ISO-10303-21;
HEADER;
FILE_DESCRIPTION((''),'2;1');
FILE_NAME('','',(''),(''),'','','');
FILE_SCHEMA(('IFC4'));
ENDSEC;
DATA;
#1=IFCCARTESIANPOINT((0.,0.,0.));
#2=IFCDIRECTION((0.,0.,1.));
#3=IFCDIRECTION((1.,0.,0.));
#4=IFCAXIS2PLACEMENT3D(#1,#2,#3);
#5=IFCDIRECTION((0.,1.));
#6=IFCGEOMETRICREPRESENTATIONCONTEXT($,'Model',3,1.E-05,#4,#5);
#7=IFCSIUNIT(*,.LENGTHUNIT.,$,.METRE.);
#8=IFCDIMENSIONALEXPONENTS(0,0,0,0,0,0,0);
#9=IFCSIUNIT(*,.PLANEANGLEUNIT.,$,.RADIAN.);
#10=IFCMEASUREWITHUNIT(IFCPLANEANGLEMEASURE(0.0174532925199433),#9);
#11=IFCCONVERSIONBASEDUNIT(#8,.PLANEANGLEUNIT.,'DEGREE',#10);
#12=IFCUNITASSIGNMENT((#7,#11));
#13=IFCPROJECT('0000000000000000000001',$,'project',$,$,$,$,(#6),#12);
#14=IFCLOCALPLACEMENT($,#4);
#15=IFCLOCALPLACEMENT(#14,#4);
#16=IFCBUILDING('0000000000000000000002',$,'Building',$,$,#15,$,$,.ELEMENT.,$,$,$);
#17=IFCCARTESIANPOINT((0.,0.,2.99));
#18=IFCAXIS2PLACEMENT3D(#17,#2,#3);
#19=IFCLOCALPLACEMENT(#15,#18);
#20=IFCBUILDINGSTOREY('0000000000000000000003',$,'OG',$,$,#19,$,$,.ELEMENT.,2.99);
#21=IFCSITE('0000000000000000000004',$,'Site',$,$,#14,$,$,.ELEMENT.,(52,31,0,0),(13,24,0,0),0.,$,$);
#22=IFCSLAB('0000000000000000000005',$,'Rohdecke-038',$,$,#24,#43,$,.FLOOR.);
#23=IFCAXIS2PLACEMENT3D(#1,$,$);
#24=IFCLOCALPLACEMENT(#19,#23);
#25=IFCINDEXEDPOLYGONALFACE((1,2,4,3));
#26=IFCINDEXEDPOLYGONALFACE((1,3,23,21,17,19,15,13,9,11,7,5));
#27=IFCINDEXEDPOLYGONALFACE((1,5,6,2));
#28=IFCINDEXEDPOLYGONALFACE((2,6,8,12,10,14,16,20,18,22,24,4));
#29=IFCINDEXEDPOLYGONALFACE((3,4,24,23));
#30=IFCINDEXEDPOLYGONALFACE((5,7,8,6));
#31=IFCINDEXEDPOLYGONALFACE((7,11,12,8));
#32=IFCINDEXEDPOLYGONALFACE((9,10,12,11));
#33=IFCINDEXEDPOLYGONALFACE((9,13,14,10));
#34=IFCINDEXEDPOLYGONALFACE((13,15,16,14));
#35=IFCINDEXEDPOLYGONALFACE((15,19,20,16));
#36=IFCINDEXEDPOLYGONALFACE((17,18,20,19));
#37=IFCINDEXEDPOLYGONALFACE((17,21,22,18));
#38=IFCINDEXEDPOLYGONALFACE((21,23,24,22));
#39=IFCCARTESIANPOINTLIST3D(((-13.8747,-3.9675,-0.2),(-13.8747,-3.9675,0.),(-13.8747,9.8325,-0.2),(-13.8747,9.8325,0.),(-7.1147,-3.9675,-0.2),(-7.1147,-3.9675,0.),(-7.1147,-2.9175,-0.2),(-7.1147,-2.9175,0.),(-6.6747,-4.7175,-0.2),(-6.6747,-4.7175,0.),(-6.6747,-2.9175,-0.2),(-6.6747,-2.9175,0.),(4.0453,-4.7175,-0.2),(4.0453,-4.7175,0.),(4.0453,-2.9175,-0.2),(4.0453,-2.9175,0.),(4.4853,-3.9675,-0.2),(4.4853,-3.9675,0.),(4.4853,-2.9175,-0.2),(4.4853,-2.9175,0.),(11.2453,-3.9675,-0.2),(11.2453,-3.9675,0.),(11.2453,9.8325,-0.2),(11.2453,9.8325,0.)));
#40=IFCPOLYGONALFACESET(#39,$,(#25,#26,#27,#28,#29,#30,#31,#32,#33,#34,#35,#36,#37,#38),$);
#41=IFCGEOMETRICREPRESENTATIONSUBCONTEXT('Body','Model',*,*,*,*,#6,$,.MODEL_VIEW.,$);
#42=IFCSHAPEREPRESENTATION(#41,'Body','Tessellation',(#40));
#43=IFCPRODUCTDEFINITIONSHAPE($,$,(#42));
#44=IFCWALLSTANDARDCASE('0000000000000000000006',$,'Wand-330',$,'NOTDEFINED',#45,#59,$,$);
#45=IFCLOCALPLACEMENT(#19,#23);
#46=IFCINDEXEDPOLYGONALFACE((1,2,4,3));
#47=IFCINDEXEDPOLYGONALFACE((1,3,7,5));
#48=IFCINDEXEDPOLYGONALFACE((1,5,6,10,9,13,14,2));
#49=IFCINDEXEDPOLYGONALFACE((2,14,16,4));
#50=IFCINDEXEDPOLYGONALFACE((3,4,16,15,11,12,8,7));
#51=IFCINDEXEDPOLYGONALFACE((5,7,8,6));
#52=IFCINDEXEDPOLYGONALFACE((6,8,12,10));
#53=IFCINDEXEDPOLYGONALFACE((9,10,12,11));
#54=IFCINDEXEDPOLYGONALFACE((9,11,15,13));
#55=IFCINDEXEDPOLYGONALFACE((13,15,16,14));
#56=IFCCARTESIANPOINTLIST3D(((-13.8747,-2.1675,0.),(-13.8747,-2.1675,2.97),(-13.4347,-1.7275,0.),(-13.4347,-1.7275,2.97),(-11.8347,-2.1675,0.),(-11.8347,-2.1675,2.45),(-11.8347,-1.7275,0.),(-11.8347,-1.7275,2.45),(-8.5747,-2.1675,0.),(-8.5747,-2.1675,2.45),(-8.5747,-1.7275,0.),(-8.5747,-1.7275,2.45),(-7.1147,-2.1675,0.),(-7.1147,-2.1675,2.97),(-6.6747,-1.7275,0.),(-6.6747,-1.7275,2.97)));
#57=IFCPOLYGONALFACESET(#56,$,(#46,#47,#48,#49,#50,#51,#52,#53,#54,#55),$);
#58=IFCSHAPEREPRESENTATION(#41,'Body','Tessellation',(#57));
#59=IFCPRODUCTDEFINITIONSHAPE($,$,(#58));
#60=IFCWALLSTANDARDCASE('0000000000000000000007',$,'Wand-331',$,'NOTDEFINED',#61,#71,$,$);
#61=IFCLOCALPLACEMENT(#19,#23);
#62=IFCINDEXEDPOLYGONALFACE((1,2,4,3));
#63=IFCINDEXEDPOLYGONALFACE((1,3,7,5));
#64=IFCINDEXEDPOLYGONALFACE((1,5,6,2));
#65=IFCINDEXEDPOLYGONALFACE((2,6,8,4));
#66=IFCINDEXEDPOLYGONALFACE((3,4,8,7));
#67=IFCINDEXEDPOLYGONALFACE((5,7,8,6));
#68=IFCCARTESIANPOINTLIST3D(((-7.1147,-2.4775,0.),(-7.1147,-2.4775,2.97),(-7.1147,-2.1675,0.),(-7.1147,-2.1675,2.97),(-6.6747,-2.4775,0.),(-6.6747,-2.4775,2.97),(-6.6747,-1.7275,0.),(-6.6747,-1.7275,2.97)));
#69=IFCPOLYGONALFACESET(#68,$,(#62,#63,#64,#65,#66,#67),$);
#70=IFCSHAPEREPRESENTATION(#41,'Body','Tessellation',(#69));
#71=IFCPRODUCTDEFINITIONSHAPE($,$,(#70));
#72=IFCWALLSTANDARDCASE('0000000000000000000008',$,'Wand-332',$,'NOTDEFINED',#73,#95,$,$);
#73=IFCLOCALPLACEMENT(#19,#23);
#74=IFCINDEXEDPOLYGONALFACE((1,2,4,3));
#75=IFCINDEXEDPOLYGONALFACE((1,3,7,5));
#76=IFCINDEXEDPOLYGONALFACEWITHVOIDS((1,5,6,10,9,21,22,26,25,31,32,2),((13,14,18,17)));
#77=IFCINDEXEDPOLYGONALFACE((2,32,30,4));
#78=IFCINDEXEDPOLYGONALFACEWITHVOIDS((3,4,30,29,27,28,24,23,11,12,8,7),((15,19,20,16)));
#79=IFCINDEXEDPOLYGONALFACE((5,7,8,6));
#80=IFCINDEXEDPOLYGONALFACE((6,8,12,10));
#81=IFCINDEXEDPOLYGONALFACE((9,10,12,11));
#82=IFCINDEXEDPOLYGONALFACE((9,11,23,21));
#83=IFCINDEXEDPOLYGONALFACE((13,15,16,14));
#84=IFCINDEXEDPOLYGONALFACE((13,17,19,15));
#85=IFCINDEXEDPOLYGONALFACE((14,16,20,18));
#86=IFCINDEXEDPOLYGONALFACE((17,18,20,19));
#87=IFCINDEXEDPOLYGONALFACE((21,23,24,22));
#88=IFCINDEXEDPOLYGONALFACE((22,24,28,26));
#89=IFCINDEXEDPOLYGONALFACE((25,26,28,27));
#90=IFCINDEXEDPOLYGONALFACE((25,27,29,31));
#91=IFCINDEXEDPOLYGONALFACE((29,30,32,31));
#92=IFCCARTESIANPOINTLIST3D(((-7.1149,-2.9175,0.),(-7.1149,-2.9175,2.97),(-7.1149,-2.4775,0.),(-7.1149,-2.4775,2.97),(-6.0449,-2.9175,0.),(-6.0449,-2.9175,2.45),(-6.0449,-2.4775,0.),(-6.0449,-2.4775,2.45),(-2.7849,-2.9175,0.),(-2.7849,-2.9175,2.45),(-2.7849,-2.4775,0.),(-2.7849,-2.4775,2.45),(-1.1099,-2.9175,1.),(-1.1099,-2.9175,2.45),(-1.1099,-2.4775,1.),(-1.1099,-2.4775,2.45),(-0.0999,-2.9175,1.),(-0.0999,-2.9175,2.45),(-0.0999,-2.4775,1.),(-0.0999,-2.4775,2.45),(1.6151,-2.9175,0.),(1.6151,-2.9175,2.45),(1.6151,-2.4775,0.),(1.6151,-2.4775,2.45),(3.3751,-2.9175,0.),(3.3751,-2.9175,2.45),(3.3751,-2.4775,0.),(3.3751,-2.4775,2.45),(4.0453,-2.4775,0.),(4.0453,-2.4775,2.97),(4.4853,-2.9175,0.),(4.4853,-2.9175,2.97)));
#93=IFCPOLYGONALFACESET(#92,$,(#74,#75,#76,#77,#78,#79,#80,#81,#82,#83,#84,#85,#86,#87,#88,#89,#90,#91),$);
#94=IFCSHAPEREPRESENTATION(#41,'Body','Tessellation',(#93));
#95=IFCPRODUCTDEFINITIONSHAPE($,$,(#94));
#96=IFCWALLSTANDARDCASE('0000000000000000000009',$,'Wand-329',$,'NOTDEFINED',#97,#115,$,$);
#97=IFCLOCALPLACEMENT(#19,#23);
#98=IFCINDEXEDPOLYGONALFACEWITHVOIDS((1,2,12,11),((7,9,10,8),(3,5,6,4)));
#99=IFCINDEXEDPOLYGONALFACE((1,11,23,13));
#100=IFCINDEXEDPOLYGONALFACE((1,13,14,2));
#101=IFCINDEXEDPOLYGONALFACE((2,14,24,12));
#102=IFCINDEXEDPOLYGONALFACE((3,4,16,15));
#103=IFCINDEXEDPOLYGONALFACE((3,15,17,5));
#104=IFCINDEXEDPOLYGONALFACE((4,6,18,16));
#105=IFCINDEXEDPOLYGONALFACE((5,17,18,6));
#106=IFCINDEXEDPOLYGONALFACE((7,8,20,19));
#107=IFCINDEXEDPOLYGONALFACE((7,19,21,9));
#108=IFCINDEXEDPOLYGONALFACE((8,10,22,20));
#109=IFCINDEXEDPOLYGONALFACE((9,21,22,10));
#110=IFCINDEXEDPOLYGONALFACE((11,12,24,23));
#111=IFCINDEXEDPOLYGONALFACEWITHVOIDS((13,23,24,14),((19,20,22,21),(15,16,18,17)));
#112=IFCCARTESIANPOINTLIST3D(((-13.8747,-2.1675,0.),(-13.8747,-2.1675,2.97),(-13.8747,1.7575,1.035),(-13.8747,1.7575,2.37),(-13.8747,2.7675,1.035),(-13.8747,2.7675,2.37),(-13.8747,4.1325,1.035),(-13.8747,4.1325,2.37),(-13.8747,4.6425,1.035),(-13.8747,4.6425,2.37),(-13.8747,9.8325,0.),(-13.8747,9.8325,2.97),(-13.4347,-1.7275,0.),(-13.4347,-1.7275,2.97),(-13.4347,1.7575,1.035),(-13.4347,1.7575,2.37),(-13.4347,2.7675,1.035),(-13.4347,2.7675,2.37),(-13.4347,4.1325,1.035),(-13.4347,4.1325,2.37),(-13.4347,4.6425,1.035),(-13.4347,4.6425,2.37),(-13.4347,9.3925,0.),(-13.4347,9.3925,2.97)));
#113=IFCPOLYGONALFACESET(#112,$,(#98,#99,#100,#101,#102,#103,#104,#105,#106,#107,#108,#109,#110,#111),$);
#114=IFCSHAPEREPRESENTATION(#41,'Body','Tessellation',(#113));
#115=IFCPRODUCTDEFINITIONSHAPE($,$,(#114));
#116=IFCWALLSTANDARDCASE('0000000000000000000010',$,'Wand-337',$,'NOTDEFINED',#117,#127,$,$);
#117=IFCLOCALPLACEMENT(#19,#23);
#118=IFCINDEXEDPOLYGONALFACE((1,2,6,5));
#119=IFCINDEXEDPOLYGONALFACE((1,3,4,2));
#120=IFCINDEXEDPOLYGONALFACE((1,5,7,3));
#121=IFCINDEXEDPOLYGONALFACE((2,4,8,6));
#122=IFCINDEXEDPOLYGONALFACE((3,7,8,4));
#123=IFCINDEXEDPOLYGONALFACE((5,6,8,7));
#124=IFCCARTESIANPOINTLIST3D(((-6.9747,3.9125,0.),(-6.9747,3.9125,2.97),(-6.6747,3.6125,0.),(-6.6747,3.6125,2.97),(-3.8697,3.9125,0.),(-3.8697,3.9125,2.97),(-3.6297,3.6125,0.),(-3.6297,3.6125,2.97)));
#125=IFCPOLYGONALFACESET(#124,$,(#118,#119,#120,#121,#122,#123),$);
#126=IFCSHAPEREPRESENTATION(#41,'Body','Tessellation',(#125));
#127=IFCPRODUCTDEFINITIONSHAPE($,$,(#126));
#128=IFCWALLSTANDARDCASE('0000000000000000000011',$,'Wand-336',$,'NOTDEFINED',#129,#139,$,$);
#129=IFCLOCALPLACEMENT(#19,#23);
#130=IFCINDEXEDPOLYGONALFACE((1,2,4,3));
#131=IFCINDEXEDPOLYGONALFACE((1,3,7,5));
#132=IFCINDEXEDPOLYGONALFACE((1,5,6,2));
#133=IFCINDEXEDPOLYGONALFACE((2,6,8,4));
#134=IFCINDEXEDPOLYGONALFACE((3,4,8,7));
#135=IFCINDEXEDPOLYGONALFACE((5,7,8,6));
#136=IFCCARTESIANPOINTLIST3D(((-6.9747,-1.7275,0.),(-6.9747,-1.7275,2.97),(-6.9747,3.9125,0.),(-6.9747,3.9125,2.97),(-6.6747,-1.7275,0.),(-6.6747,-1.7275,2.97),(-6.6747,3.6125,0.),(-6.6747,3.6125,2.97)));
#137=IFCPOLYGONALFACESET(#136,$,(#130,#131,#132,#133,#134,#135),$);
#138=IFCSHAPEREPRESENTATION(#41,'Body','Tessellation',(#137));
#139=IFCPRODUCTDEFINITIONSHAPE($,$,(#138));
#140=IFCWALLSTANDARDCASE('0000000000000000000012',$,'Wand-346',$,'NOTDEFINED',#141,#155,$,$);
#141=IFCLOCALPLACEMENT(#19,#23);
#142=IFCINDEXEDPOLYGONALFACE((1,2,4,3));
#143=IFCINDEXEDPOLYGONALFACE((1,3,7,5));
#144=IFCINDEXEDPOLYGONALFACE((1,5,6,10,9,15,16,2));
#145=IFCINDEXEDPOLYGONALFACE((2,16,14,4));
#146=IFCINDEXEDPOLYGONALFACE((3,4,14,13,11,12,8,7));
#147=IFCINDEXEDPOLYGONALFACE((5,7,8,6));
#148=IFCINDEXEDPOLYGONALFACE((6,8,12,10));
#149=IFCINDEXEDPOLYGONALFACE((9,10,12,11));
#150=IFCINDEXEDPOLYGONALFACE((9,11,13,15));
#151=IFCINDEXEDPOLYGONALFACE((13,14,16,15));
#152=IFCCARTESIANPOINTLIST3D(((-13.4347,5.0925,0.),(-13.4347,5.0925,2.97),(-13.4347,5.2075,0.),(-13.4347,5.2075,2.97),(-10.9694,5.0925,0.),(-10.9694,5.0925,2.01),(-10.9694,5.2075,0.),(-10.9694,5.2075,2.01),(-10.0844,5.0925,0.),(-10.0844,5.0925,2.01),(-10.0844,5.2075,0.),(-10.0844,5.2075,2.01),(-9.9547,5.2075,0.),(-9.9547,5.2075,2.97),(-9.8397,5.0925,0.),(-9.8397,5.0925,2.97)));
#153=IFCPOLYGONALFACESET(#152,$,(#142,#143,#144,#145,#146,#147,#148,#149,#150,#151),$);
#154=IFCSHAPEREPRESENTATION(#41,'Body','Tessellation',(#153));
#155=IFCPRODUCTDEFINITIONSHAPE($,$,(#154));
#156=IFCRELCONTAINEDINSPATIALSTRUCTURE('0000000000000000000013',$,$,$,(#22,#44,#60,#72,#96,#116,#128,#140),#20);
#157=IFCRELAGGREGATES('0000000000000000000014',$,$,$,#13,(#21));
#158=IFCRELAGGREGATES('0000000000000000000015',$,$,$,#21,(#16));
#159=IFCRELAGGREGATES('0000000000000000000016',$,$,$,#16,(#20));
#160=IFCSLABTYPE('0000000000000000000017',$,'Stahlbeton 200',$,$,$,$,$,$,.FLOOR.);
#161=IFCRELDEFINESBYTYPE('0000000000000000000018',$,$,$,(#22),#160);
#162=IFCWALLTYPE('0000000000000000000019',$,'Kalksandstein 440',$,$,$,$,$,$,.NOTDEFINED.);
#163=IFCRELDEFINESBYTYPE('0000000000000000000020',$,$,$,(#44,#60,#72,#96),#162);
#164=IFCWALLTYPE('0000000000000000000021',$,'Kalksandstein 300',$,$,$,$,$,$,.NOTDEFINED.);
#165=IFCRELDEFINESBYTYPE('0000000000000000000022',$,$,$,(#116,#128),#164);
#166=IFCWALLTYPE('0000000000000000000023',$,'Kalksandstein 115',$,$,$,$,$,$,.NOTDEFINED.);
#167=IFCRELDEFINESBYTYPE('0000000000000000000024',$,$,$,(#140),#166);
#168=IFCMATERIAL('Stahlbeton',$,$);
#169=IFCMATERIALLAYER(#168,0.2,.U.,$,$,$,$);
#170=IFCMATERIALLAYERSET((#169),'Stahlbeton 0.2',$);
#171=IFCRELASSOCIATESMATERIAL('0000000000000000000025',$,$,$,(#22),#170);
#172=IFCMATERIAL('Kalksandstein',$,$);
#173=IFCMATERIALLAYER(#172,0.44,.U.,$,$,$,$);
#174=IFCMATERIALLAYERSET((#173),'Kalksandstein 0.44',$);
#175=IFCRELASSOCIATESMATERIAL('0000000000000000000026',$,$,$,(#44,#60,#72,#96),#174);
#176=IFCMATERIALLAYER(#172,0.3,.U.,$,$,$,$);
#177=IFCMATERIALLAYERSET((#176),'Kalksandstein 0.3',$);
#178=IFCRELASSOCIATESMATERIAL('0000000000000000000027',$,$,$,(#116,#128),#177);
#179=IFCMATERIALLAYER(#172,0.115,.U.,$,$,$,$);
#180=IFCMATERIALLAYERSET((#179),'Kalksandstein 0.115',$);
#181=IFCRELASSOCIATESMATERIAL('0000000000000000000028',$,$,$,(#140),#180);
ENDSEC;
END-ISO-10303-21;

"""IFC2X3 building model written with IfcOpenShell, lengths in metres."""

from ifc_helpers import new_model, entity, si_unit, converted_unit, direction, frame, origin_with_axes, origin_2d_with_axis, place, context, subcontext, project, spatial, polyline, rectangle, outline, extrude, material, layer, layer_set, layer_usage, type_object, element, save


model = new_model("IFC2X3")

# Units and contexts
model_context = context("Model", 3, precision=1e-05, world=origin_with_axes(), true_north=direction((0.0, 1.0)))
body_context = subcontext(model_context, "Body", "Model", "MODEL_VIEW")
ifc_project = project(units=[si_unit("LENGTHUNIT", "METRE"), converted_unit("PLANEANGLEUNIT", "DEGREE", entity("IfcPlaneAngleMeasure", 0.0174532925199433), si_unit("PLANEANGLEUNIT", "RADIAN"), dimensions=[0, 0, 0, 0, 0, 0, 0])], contexts=[model_context])

# Site, building, storey
site_placement = place(None, origin_with_axes())
site = spatial("IfcSite", under=ifc_project, at=site_placement, Name="Site", CompositionType="ELEMENT", RefLatitude=(52, 31, 0, 0), RefLongitude=(13, 24, 0, 0), RefElevation=0.0)
building_placement = place(site_placement, origin_with_axes())
building = spatial("IfcBuilding", under=site, at=building_placement, Name="Building", CompositionType="ELEMENT")
storey_placement = place(building_placement, frame((0.0, 0.0, 2.99), z_axis=(0.0, 0.0, 1.0), x_axis=(1.0, 0.0, 0.0)))
storey = spatial("IfcBuildingStorey", under=building, at=storey_placement, Name="OG", CompositionType="ELEMENT", Elevation=2.99)

# Slab
ifc_material_1 = material(Name="Stahlbeton")
ifc_layer_1 = layer(ifc_material_1, 0.2, ventilated="UNKNOWN")
ifc_layer_set_1 = layer_set([ifc_layer_1], Name="Stahlbeton 0.2")
ifc_layer_usage_1 = layer_usage(ifc_layer_set_1, "AXIS3", "NEGATIVE", 0.2)
slab_type = type_object("IfcSlabType", Name="Stahlbeton 200", PredefinedType="FLOOR")
slab_placement = place(storey_placement, frame((-13.8747, -3.9675, 0.0), z_axis=(0.0, 0.0, 1.0), x_axis=(1.0, 0.0, 0.0)))
element("IfcSlab", 1, at=slab_placement, inside=storey, type_object=slab_type, material=ifc_layer_usage_1, Name="Rohdecke-038", PredefinedType="FLOOR", context=body_context, shape_type="SweptSolid", body=[
    extrude(outline(polyline([(0.0, 0.0), (6.76, 0.0), (6.76, 1.05), (7.2, 1.05), (7.2, -0.75), (17.92, -0.75), (17.92, 1.05), (18.36, 1.05), (18.36, 0.0), (25.12, 0.0), (25.12, 13.8), (0.0, 13.8), (0.0, 0.0)])), frame((0.0, 0.0, -0.2), z_axis=(0.0, 0.0, 1.0), x_axis=(1.0, 0.0, 0.0)), (0.0, 0.0, 1.0), 0.2),
])

# Wall, opening
ifc_material_2 = material(Name="Kalksandstein")
ifc_layer_2 = layer(ifc_material_2, 0.44, ventilated="UNKNOWN")
ifc_layer_set_2 = layer_set([ifc_layer_2], Name="Kalksandstein 0.44")
ifc_layer_usage_2 = layer_usage(ifc_layer_set_2, "AXIS2", "NEGATIVE", 0.44)
wall_type_1 = type_object("IfcWallType", Name="Kalksandstein 440", PredefinedType="NOTDEFINED")
wall_1_placement = place(storey_placement, frame((-13.8747, -2.1675, 0.0), z_axis=(0.0, 0.0, 1.0), x_axis=(1.0, 0.0, 0.0)))
wall_1 = element("IfcWallStandardCase", 2, at=wall_1_placement, inside=storey, type_object=wall_type_1, material=ifc_layer_usage_2, Name="Wand-330", ObjectType="NOTDEFINED", context=body_context, shape_type="SweptSolid", body=[
    extrude(outline(polyline([(0.0, 0.0), (6.76, 0.0), (7.2, 0.44), (0.44, 0.44), (0.0, 0.0)])), origin_with_axes(), (0.0, 0.0, 1.0), 2.97),
])
opening_1_placement = place(wall_1_placement, frame((3.67, 0.0, 0.0), z_axis=(0.0, 0.0, 1.0), x_axis=(1.0, 0.0, 0.0)))
element("IfcOpeningElement", 3, at=opening_1_placement, cuts=wall_1, context=body_context, shape_type="SweptSolid", body=[
    extrude(rectangle(XDim=3.26, YDim=2.45, at=origin_2d_with_axis()), frame((0.0, 0.44, 1.225), z_axis=(0.0, -1.0, 0.0), x_axis=(-1.0, 0.0, 0.0)), (0.0, 0.0, 1.0), 1.32),
])

# Wall
ifc_layer_usage_3 = layer_usage(ifc_layer_set_2, "AXIS2", "NEGATIVE", 0.44)
wall_2_placement = place(storey_placement, frame((-7.1147, -2.1675, 0.0), z_axis=(0.0, 0.0, 1.0), x_axis=(0.0, -1.0, 0.0)))
element("IfcWallStandardCase", 4, at=wall_2_placement, inside=storey, type_object=wall_type_1, material=ifc_layer_usage_3, Name="Wand-331", ObjectType="NOTDEFINED", context=body_context, shape_type="SweptSolid", body=[
    extrude(outline(polyline([(0.0, 0.0), (0.31, 0.0), (0.31, 0.44), (-0.44, 0.44), (0.0, 0.0)])), origin_with_axes(), (0.0, 0.0, 1.0), 2.97),
])

# Walls, openings
ifc_layer_usage_4 = layer_usage(ifc_layer_set_2, "AXIS2", "NEGATIVE", 0.44)
wall_3_placement = place(storey_placement, frame((-7.1149, -2.9175, 0.0), z_axis=(0.0, 0.0, 1.0), x_axis=(1.0, 0.0, 0.0)))
wall_3 = element("IfcWallStandardCase", 5, at=wall_3_placement, inside=storey, type_object=wall_type_1, material=ifc_layer_usage_4, Name="Wand-332", ObjectType="NOTDEFINED", context=body_context, shape_type="SweptSolid", body=[
    extrude(outline(polyline([(0.0, 0.0), (11.6002, 0.0), (11.1602, 0.44), (0.0, 0.44), (0.0, 0.0)])), origin_with_axes(), (0.0, 0.0, 1.0), 2.97),
])
opening_2_placement = place(wall_3_placement, frame((2.7, 0.0, 0.0), z_axis=(0.0, 0.0, 1.0), x_axis=(1.0, 0.0, 0.0)))
element("IfcOpeningElement", 6, at=opening_2_placement, cuts=wall_3, context=body_context, shape_type="SweptSolid", body=[
    extrude(rectangle(XDim=3.26, YDim=2.45, at=origin_2d_with_axis()), frame((0.0, 0.44, 1.225), z_axis=(0.0, -1.0, 0.0), x_axis=(-1.0, 0.0, 0.0)), (0.0, 0.0, 1.0), 1.32),
])
opening_3_placement = place(wall_3_placement, frame((9.61, 0.0, 0.0), z_axis=(0.0, 0.0, 1.0), x_axis=(1.0, 0.0, 0.0)))
element("IfcOpeningElement", 7, at=opening_3_placement, cuts=wall_3, context=body_context, shape_type="SweptSolid", body=[
    extrude(rectangle(XDim=1.76, YDim=2.45, at=origin_2d_with_axis()), frame((0.0, 0.44, 1.225), z_axis=(0.0, -1.0, 0.0), x_axis=(-1.0, 0.0, 0.0)), (0.0, 0.0, 1.0), 1.32),
])
opening_4_placement = place(wall_3_placement, frame((6.51, 0.0, 1.0), z_axis=(0.0, 0.0, 1.0), x_axis=(1.0, 0.0, 0.0)))
element("IfcOpeningElement", 8, at=opening_4_placement, cuts=wall_3, context=body_context, shape_type="SweptSolid", body=[
    extrude(rectangle(XDim=1.01, YDim=1.45, at=origin_2d_with_axis()), frame((0.0, 0.44, 0.725), z_axis=(0.0, -1.0, 0.0), x_axis=(-1.0, 0.0, 0.0)), (0.0, 0.0, 1.0), 1.32),
])
ifc_layer_usage_5 = layer_usage(ifc_layer_set_2, "AXIS2", "NEGATIVE", 0.44)
wall_4_placement = place(storey_placement, frame((-13.8747, 9.8325, 0.0), z_axis=(0.0, 0.0, 1.0), x_axis=(0.0, -1.0, 0.0)))
wall_4 = element("IfcWallStandardCase", 9, at=wall_4_placement, inside=storey, type_object=wall_type_1, material=ifc_layer_usage_5, Name="Wand-329", ObjectType="NOTDEFINED", context=body_context, shape_type="SweptSolid", body=[
    extrude(outline(polyline([(0.0, 0.0), (12.0, 0.0), (11.56, 0.44), (0.44, 0.44), (0.0, 0.0)])), origin_with_axes(), (0.0, 0.0, 1.0), 2.97),
])
opening_5_placement = place(wall_4_placement, frame((7.57, 0.0, 1.035), z_axis=(0.0, 0.0, 1.0), x_axis=(1.0, 0.0, 0.0)))
element("IfcOpeningElement", 10, at=opening_5_placement, cuts=wall_4, context=body_context, shape_type="SweptSolid", body=[
    extrude(rectangle(XDim=1.01, YDim=1.335, at=origin_2d_with_axis()), frame((0.0, 0.44, 0.6675), z_axis=(0.0, -1.0, 0.0), x_axis=(-1.0, 0.0, 0.0)), (0.0, 0.0, 1.0), 1.32),
])
opening_6_placement = place(wall_4_placement, frame((5.445, 0.0, 1.035), z_axis=(0.0, 0.0, 1.0), x_axis=(1.0, 0.0, 0.0)))
element("IfcOpeningElement", 11, at=opening_6_placement, cuts=wall_4, context=body_context, shape_type="SweptSolid", body=[
    extrude(rectangle(XDim=0.51, YDim=1.335, at=origin_2d_with_axis()), frame((0.0, 0.44, 0.6675), z_axis=(0.0, -1.0, 0.0), x_axis=(-1.0, 0.0, 0.0)), (0.0, 0.0, 1.0), 1.32),
])

# Walls
ifc_layer_3 = layer(ifc_material_2, 0.3, ventilated="UNKNOWN")
ifc_layer_set_3 = layer_set([ifc_layer_3], Name="Kalksandstein 0.3")
ifc_layer_usage_6 = layer_usage(ifc_layer_set_3, "AXIS2", "NEGATIVE", 0.3)
wall_type_2 = type_object("IfcWallType", Name="Kalksandstein 300", PredefinedType="NOTDEFINED")
wall_5_placement = place(storey_placement, frame((-6.9747, 3.6125, 0.0), z_axis=(0.0, 0.0, 1.0), x_axis=(1.0, 0.0, 0.0)))
element("IfcWallStandardCase", 12, at=wall_5_placement, inside=storey, type_object=wall_type_2, material=ifc_layer_usage_6, Name="Wand-337", ObjectType="NOTDEFINED", context=body_context, shape_type="SweptSolid", body=[
    extrude(outline(polyline([(0.3, 0.0), (3.345, 0.0), (3.105, 0.3), (0.0, 0.3), (0.3, 0.0)])), origin_with_axes(), (0.0, 0.0, 1.0), 2.97),
])
ifc_layer_usage_7 = layer_usage(ifc_layer_set_3, "AXIS2", "POSITIVE", -0.3)
wall_6_placement = place(storey_placement, frame((-6.9747, -1.7275, 0.0), z_axis=(0.0, 0.0, 1.0), x_axis=(0.0, 1.0, 0.0)))
element("IfcWallStandardCase", 13, at=wall_6_placement, inside=storey, type_object=wall_type_2, material=ifc_layer_usage_7, Name="Wand-336", ObjectType="NOTDEFINED", context=body_context, shape_type="SweptSolid", body=[
    extrude(outline(polyline([(0.0, -0.3), (5.34, -0.3), (5.64, 0.0), (0.0, 0.0), (0.0, -0.3)])), origin_with_axes(), (0.0, 0.0, 1.0), 2.97),
])

# Wall, opening
ifc_layer_4 = layer(ifc_material_2, 0.115, ventilated="UNKNOWN")
ifc_layer_set_4 = layer_set([ifc_layer_4], Name="Kalksandstein 0.115")
ifc_layer_usage_8 = layer_usage(ifc_layer_set_4, "AXIS2", "POSITIVE", -0.115)
wall_type_3 = type_object("IfcWallType", Name="Kalksandstein 115", PredefinedType="NOTDEFINED")
wall_7_placement = place(storey_placement, frame((-9.9547, 5.0925, 0.0), z_axis=(0.0, 0.0, 1.0), x_axis=(-1.0, 0.0, 0.0)))
wall_7 = element("IfcWallStandardCase", 14, at=wall_7_placement, inside=storey, type_object=wall_type_3, material=ifc_layer_usage_8, Name="Wand-346", ObjectType="NOTDEFINED", context=body_context, shape_type="SweptSolid", body=[
    extrude(outline(polyline([(0.0, -0.115), (3.48, -0.115), (3.48, 0.0), (-0.115, 0.0), (0.0, -0.115)])), origin_with_axes(), (0.0, 0.0, 1.0), 2.97),
])
opening_7_placement = place(wall_7_placement, frame((0.5722, 0.0, 0.0), z_axis=(0.0, 0.0, 1.0), x_axis=(1.0, 0.0, 0.0)))
element("IfcOpeningElement", 15, at=opening_7_placement, cuts=wall_7, context=body_context, shape_type="SweptSolid", body=[
    extrude(rectangle(XDim=0.885, YDim=2.01, at=origin_2d_with_axis()), frame((0.0, 0.115, 1.005), z_axis=(0.0, -1.0, 0.0), x_axis=(-1.0, 0.0, 0.0)), (0.0, 0.0, 1.0), 0.345),
])

save(model, "model.ifc")
